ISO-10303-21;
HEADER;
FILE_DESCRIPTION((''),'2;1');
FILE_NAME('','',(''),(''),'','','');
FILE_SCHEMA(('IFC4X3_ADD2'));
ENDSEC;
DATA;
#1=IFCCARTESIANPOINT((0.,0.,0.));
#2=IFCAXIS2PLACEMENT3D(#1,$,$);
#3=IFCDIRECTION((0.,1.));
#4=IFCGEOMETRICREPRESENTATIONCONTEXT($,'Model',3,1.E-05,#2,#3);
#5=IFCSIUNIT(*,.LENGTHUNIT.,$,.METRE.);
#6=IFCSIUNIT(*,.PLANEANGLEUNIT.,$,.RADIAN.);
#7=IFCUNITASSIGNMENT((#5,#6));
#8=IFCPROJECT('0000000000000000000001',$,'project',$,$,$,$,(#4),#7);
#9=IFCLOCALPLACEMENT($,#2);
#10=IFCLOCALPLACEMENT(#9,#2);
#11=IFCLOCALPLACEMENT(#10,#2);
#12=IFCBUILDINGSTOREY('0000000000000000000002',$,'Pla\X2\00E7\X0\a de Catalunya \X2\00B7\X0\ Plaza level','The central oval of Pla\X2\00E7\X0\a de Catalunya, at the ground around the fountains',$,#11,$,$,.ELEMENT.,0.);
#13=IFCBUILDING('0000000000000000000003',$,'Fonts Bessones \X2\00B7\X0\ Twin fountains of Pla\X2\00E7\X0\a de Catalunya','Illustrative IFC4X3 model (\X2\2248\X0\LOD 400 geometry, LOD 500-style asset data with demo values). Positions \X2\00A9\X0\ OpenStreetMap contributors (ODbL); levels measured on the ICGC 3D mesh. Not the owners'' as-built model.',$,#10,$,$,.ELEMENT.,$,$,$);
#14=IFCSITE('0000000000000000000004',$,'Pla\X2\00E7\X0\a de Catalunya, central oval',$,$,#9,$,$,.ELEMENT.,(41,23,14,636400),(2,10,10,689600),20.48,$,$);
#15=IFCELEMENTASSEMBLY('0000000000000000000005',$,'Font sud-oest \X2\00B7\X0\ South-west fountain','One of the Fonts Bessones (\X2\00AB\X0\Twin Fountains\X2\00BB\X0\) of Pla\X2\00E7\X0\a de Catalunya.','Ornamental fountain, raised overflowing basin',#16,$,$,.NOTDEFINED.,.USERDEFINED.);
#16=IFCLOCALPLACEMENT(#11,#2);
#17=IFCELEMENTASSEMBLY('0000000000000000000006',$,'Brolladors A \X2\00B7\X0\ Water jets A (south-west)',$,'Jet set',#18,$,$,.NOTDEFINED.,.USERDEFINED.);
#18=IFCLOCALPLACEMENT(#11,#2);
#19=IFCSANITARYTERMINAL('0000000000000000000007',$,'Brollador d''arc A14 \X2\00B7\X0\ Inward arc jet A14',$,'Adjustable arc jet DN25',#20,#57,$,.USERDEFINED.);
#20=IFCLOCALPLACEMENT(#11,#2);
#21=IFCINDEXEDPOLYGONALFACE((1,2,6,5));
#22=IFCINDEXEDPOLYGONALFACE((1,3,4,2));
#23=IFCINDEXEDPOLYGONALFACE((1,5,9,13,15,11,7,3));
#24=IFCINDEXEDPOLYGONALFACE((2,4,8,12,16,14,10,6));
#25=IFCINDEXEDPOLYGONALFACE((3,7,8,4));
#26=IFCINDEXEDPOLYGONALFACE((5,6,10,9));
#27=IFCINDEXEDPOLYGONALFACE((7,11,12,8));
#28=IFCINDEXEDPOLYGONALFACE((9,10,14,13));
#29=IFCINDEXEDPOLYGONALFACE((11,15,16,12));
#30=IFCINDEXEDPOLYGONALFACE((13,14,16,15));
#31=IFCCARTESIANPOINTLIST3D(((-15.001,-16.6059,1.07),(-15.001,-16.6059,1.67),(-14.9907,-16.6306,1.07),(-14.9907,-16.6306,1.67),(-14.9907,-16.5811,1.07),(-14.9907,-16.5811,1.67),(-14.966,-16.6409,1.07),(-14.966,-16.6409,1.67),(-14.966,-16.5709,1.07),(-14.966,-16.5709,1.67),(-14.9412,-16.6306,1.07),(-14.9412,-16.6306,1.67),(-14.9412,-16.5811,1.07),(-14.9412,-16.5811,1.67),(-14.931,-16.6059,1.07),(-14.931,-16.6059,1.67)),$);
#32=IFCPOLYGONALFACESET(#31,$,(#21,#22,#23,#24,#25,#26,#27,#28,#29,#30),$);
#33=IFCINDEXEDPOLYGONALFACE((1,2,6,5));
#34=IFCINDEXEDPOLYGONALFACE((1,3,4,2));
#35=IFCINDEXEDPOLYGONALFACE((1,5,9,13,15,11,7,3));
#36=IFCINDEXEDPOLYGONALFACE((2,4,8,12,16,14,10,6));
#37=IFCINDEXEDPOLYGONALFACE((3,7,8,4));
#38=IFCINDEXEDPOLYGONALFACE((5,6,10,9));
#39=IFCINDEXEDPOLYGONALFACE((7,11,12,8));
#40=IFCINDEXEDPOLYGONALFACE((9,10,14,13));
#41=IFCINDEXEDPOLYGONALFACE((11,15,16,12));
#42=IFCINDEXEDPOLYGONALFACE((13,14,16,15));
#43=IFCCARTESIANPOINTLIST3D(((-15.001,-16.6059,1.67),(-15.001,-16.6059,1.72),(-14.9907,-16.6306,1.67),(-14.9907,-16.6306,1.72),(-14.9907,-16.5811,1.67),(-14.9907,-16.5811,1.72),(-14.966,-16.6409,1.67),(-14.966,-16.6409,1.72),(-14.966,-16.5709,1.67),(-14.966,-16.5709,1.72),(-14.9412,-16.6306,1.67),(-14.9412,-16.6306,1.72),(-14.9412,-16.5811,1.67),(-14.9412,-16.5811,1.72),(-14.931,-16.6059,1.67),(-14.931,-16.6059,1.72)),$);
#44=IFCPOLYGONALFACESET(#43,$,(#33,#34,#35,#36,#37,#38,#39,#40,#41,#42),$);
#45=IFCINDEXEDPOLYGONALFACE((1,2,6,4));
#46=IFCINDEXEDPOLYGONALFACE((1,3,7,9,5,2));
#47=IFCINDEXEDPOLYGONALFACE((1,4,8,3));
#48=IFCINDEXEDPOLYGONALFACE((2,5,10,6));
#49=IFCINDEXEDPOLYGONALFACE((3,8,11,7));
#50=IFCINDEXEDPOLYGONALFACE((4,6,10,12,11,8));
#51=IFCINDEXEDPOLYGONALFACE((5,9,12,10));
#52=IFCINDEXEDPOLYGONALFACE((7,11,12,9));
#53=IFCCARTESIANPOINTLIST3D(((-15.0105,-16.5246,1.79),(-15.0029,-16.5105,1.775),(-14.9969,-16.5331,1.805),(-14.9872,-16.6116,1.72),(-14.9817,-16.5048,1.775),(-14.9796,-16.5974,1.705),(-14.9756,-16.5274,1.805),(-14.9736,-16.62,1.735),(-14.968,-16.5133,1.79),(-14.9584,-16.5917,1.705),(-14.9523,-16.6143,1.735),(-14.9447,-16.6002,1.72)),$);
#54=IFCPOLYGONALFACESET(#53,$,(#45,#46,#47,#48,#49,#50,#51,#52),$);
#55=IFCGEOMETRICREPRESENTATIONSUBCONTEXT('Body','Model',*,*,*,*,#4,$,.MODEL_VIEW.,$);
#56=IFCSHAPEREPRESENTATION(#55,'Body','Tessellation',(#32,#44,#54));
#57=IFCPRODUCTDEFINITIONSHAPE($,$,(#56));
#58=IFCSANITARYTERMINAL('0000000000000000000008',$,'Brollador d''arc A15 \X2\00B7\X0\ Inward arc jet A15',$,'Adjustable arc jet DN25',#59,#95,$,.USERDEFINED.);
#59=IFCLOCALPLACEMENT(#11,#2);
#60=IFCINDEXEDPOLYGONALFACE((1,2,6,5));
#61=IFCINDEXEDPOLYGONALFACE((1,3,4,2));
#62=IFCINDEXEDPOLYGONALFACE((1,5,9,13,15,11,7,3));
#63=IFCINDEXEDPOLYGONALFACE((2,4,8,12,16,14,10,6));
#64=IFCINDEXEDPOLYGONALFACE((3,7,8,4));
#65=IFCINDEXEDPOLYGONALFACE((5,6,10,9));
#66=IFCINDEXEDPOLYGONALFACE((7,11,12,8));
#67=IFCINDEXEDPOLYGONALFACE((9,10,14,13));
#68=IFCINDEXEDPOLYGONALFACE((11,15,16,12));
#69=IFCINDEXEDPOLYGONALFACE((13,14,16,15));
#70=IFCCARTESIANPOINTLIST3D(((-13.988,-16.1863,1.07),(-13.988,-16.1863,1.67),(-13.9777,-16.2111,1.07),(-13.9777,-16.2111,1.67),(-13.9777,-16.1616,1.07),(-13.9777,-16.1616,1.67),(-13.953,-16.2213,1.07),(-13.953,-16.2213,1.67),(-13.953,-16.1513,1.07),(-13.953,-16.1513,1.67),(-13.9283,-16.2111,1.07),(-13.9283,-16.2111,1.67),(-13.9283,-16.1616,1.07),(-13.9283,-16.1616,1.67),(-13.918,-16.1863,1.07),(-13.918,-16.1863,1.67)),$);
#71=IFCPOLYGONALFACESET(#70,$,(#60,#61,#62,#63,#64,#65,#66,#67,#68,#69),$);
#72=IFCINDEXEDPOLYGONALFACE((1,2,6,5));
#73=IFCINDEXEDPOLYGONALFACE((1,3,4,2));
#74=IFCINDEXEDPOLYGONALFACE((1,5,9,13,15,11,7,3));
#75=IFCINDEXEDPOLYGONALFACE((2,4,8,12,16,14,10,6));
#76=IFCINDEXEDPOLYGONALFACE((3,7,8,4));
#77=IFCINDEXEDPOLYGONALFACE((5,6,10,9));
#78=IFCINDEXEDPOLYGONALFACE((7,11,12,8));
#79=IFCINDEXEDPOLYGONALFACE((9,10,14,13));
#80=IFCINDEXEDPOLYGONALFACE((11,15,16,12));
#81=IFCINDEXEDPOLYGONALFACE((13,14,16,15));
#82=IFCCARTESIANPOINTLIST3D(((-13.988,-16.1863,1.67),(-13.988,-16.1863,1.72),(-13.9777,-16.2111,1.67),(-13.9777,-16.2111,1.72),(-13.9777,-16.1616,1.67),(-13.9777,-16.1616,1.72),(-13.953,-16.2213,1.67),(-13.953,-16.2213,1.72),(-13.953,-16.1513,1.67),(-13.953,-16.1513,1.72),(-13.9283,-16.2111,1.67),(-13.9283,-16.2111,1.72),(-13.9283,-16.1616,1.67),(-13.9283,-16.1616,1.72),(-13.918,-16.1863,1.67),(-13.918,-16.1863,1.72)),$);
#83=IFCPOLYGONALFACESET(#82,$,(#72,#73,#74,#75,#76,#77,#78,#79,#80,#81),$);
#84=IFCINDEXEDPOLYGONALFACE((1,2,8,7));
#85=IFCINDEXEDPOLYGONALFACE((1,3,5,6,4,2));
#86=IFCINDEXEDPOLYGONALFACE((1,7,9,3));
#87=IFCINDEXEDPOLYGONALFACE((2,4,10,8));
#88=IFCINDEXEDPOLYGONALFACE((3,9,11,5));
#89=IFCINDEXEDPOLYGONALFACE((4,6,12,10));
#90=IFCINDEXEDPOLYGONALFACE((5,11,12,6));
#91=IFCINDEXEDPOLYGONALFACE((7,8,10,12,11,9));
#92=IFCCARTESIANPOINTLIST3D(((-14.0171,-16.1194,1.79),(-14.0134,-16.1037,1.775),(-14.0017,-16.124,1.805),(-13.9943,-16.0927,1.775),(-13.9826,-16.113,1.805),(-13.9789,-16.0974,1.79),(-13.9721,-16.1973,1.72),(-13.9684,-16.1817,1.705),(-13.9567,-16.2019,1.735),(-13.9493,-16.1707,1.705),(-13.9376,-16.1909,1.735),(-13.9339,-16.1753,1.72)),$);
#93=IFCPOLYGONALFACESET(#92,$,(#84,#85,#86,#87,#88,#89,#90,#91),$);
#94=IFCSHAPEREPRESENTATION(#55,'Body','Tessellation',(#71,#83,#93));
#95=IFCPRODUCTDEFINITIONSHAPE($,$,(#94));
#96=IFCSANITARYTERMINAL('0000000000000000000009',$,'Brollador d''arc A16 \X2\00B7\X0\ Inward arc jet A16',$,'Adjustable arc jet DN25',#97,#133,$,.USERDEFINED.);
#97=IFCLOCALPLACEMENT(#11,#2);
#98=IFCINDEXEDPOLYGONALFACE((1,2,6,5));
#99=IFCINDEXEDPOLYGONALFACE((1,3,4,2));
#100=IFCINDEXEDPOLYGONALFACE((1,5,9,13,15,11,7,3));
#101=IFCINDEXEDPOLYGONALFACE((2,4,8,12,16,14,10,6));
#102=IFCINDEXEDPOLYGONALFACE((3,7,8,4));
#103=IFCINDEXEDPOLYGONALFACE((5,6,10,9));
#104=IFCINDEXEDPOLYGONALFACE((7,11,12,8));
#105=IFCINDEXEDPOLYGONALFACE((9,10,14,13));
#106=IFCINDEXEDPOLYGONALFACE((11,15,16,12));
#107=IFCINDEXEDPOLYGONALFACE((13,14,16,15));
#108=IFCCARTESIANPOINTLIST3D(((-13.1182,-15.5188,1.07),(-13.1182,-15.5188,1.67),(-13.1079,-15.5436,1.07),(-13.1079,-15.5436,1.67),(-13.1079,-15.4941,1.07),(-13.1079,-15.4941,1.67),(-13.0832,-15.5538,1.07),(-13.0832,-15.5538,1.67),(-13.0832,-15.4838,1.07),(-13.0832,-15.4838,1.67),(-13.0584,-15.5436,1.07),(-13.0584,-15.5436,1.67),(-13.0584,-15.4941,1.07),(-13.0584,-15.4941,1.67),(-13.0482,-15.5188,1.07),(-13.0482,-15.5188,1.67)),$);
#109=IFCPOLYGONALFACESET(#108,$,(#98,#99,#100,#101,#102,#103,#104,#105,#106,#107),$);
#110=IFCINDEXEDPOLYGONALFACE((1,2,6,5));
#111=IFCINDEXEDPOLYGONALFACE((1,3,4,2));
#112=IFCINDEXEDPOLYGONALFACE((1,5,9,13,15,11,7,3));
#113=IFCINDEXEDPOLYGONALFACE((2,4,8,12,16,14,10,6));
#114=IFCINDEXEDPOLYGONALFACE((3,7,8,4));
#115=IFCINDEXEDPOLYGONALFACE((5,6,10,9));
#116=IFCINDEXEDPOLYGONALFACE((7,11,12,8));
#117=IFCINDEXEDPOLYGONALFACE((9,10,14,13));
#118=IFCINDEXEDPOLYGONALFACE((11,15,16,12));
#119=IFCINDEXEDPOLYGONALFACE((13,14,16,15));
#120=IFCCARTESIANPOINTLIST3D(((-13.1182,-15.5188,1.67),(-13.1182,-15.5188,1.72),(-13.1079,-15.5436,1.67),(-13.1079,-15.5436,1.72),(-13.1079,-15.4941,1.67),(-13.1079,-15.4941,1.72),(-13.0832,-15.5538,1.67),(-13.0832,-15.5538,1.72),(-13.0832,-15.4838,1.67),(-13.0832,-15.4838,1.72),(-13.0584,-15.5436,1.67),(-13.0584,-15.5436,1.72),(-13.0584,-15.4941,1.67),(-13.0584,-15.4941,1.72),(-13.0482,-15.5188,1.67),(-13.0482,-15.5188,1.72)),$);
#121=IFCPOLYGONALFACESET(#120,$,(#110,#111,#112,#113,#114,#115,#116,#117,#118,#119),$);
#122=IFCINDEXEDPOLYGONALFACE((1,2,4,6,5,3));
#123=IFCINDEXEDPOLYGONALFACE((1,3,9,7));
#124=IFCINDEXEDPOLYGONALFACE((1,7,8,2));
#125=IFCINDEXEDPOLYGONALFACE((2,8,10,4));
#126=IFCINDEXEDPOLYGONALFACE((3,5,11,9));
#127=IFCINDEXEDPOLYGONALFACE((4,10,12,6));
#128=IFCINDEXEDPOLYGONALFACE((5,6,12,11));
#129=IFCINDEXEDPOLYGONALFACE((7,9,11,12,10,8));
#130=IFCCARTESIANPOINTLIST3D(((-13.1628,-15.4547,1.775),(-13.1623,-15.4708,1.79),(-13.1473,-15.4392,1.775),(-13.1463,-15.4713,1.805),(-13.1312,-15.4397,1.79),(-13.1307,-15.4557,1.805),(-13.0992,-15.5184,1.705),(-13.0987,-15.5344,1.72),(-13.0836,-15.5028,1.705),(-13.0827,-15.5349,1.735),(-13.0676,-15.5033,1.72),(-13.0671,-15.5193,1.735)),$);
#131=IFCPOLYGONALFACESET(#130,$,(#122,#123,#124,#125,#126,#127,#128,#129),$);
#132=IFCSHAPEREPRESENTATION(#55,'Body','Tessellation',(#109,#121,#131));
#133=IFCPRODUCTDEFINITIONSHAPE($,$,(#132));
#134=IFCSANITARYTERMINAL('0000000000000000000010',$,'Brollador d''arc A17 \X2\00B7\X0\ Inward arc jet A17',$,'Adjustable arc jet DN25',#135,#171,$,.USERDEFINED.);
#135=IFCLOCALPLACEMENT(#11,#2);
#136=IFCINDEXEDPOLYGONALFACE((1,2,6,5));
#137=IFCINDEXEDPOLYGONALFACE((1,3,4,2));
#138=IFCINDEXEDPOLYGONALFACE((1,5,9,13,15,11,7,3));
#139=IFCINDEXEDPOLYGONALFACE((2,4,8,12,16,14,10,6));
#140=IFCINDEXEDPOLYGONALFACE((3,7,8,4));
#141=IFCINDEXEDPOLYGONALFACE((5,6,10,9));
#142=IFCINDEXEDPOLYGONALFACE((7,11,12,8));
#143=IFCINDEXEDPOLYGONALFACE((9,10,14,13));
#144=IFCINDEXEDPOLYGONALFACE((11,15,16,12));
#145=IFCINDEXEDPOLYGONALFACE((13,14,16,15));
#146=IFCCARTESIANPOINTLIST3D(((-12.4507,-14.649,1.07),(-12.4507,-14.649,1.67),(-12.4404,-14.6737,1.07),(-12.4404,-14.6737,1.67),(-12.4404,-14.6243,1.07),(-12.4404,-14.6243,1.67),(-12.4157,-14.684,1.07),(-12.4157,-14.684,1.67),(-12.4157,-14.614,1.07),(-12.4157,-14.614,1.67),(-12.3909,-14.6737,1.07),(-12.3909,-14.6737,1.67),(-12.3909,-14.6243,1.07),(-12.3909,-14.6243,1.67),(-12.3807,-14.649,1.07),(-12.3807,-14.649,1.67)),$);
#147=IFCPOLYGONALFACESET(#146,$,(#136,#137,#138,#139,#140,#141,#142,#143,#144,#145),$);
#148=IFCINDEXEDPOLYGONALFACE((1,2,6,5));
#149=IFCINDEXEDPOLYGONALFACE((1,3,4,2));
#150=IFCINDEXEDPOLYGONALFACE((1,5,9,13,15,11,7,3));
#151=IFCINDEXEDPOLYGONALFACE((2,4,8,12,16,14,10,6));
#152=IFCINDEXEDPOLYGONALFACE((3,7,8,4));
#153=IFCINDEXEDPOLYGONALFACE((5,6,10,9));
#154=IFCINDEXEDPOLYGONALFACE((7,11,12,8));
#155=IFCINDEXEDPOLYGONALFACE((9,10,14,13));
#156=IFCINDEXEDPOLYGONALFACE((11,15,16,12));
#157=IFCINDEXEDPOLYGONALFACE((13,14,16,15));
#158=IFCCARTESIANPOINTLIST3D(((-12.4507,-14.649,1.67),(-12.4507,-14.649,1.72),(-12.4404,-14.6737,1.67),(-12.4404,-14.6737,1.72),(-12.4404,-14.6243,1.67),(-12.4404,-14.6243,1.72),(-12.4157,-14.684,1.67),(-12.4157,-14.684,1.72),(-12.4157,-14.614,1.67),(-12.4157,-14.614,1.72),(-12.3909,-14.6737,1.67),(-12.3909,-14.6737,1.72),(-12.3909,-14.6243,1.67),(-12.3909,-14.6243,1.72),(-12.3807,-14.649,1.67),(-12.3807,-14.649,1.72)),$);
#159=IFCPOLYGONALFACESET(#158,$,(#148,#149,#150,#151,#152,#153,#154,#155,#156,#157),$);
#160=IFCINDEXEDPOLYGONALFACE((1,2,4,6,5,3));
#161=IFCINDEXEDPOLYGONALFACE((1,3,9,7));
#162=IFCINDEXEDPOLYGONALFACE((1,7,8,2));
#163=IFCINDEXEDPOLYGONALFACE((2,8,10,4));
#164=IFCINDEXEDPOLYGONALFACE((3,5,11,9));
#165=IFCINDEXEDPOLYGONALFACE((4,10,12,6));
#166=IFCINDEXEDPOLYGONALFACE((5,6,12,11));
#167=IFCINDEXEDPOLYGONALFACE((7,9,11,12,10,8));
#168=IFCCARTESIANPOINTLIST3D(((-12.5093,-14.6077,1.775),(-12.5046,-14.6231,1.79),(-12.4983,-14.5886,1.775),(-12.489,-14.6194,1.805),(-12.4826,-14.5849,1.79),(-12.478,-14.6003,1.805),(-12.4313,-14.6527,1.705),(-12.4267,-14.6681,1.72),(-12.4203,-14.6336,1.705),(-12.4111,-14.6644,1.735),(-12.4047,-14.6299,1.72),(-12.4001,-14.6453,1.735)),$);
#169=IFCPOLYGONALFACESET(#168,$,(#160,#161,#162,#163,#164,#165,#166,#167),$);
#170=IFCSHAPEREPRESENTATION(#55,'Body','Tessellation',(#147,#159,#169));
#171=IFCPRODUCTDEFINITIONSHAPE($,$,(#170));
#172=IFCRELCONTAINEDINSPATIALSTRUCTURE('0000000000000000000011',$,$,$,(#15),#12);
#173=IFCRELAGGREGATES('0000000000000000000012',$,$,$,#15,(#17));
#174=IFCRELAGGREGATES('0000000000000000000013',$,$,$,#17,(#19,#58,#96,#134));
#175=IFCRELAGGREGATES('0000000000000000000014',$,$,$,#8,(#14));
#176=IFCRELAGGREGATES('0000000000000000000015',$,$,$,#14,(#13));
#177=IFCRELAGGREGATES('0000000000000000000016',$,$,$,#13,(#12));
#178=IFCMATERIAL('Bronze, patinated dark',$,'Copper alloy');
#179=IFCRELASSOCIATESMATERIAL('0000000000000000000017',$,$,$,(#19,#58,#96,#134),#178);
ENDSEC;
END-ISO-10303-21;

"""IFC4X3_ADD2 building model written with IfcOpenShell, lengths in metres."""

from ifc_helpers import new_model, si_unit, direction, frame, origin, place, context, subcontext, project, spatial, polyline, outline, extrude, material, element, aggregate, save


model = new_model("IFC4X3_ADD2")

# Units and contexts
model_context = context("Model", 3, precision=1e-05, world=origin(), true_north=direction((0.0, 1.0)))
body_context = subcontext(model_context, "Body", "Model", "MODEL_VIEW")
ifc_project = project(units=[si_unit("LENGTHUNIT", "METRE"), si_unit("PLANEANGLEUNIT", "RADIAN")], contexts=[model_context])

# Site, building, storey
site_placement = place(None, origin())
site = spatial("IfcSite", under=ifc_project, at=site_placement, Name="Plaça de Catalunya, central oval", CompositionType="ELEMENT", RefLatitude=(41, 23, 14, 636400), RefLongitude=(2, 10, 10, 689600), RefElevation=20.48)
building_placement = place(site_placement, origin())
building = spatial("IfcBuilding", under=site, at=building_placement, Name="Fonts Bessones · Twin fountains of Plaça de Catalunya", Description="Illustrative IFC4X3 model (≈LOD 400 geometry, LOD 500-style asset data with demo values). Positions © OpenStreetMap contributors (ODbL); levels measured on the ICGC 3D mesh. Not the owners' as-built model.", CompositionType="ELEMENT")
storey_placement = place(building_placement, origin())
storey = spatial("IfcBuildingStorey", under=building, at=storey_placement, Name="Plaça de Catalunya · Plaza level", Description="The central oval of Plaça de Catalunya, at the ground around the fountains", CompositionType="ELEMENT", Elevation=0.0)

# Element assemblies, sanitary terminals
assembly_1_placement = place(building_placement, origin())
assembly_1 = element("IfcElementAssembly", 1, at=assembly_1_placement, inside=storey, Name="Font sud-oest · South-west fountain", Description="One of the Fonts Bessones («Twin Fountains») of Plaça de Catalunya.", ObjectType="Ornamental fountain, raised overflowing basin", AssemblyPlace="NOTDEFINED", PredefinedType="USERDEFINED")
assembly_2_placement = place(building_placement, origin())
assembly_2 = element("IfcElementAssembly", 2, at=assembly_2_placement, Name="Brolladors A · Water jets A (south-west)", ObjectType="Jet set", AssemblyPlace="NOTDEFINED", PredefinedType="USERDEFINED")
aggregate(assembly_1, [assembly_2])
ifc_material = material(Name="Bronze, patinated dark", Category="Copper alloy")
sanitary_terminal_1_placement = place(building_placement, origin())
sanitary_terminal_1 = element("IfcSanitaryTerminal", 3, at=sanitary_terminal_1_placement, material=ifc_material, Name="Brollador d'arc A14 · Inward arc jet A14", ObjectType="Adjustable arc jet DN25", PredefinedType="USERDEFINED", context=body_context, shape_type="SweptSolid", body=[
    extrude(outline(polyline([(-14.931, -16.6059), (-14.9412, -16.5811), (-14.966, -16.5709), (-14.9907, -16.5811), (-15.001, -16.6059), (-14.9907, -16.6306), (-14.966, -16.6409), (-14.9412, -16.6306), (-14.931, -16.6059)])), frame((0.0, 0.0, 1.07)), (0.0, 0.0, 1.0), 0.6),
    extrude(outline(polyline([(-14.931, -16.6059), (-14.9412, -16.5811), (-14.966, -16.5709), (-14.9907, -16.5811), (-15.001, -16.6059), (-14.9907, -16.6306), (-14.966, -16.6409), (-14.9412, -16.6306), (-14.931, -16.6059)])), frame((0.0, 0.0, 1.67)), (0.0, 0.0, 1.0), 0.05),
    extrude(outline(polyline([(0.022, 0.0), (0.011, 0.0191), (-0.011, 0.0191), (-0.022, 0.0), (-0.011, -0.0191), (0.011, -0.0191), (0.022, 0.0)])), frame((-14.966, -16.6059, 1.72), z_axis=(-0.204299, 0.762456, 0.613941), x_axis=(0.965926, 0.258819, 0.0)), (0.0, 0.0, 1.0), 0.114),
])
sanitary_terminal_2_placement = place(building_placement, origin())
sanitary_terminal_2 = element("IfcSanitaryTerminal", 4, at=sanitary_terminal_2_placement, material=ifc_material, Name="Brollador d'arc A15 · Inward arc jet A15", ObjectType="Adjustable arc jet DN25", PredefinedType="USERDEFINED", context=body_context, shape_type="SweptSolid", body=[
    extrude(outline(polyline([(-13.918, -16.1863), (-13.9283, -16.1616), (-13.953, -16.1513), (-13.9777, -16.1616), (-13.988, -16.1863), (-13.9777, -16.2111), (-13.953, -16.2213), (-13.9283, -16.2111), (-13.918, -16.1863)])), frame((0.0, 0.0, 1.07)), (0.0, 0.0, 1.0), 0.6),
    extrude(outline(polyline([(-13.918, -16.1863), (-13.9283, -16.1616), (-13.953, -16.1513), (-13.9777, -16.1616), (-13.988, -16.1863), (-13.9777, -16.2111), (-13.953, -16.2213), (-13.9283, -16.2111), (-13.918, -16.1863)])), frame((0.0, 0.0, 1.67)), (0.0, 0.0, 1.0), 0.05),
    extrude(outline(polyline([(0.022, 0.0), (0.011, 0.0191), (-0.011, 0.0191), (-0.022, 0.0), (-0.011, -0.0191), (0.011, -0.0191), (0.022, 0.0)])), frame((-13.953, -16.1863, 1.72), z_axis=(-0.394676, 0.683599, 0.613941), x_axis=(0.866025, 0.5, 0.0)), (0.0, 0.0, 1.0), 0.114),
])
sanitary_terminal_3_placement = place(building_placement, origin())
sanitary_terminal_3 = element("IfcSanitaryTerminal", 5, at=sanitary_terminal_3_placement, material=ifc_material, Name="Brollador d'arc A16 · Inward arc jet A16", ObjectType="Adjustable arc jet DN25", PredefinedType="USERDEFINED", context=body_context, shape_type="SweptSolid", body=[
    extrude(outline(polyline([(-13.0482, -15.5188), (-13.0584, -15.4941), (-13.0832, -15.4838), (-13.1079, -15.4941), (-13.1182, -15.5188), (-13.1079, -15.5436), (-13.0832, -15.5538), (-13.0584, -15.5436), (-13.0482, -15.5188)])), frame((0.0, 0.0, 1.07)), (0.0, 0.0, 1.0), 0.6),
    extrude(outline(polyline([(-13.0482, -15.5188), (-13.0584, -15.4941), (-13.0832, -15.4838), (-13.1079, -15.4941), (-13.1182, -15.5188), (-13.1079, -15.5436), (-13.0832, -15.5538), (-13.0584, -15.5436), (-13.0482, -15.5188)])), frame((0.0, 0.0, 1.67)), (0.0, 0.0, 1.0), 0.05),
    extrude(outline(polyline([(0.022, 0.0), (0.011, 0.0191), (-0.011, 0.0191), (-0.022, 0.0), (-0.011, -0.0191), (0.011, -0.0191), (0.022, 0.0)])), frame((-13.0832, -15.5188, 1.72), z_axis=(-0.558156, 0.558156, 0.613941), x_axis=(0.707107, 0.707107, 0.0)), (0.0, 0.0, 1.0), 0.114),
])
sanitary_terminal_4_placement = place(building_placement, origin())
sanitary_terminal_4 = element("IfcSanitaryTerminal", 6, at=sanitary_terminal_4_placement, material=ifc_material, Name="Brollador d'arc A17 · Inward arc jet A17", ObjectType="Adjustable arc jet DN25", PredefinedType="USERDEFINED", context=body_context, shape_type="SweptSolid", body=[
    extrude(outline(polyline([(-12.3807, -14.649), (-12.3909, -14.6243), (-12.4157, -14.614), (-12.4404, -14.6243), (-12.4507, -14.649), (-12.4404, -14.6737), (-12.4157, -14.684), (-12.3909, -14.6737), (-12.3807, -14.649)])), frame((0.0, 0.0, 1.07)), (0.0, 0.0, 1.0), 0.6),
    extrude(outline(polyline([(-12.3807, -14.649), (-12.3909, -14.6243), (-12.4157, -14.614), (-12.4404, -14.6243), (-12.4507, -14.649), (-12.4404, -14.6737), (-12.4157, -14.684), (-12.3909, -14.6737), (-12.3807, -14.649)])), frame((0.0, 0.0, 1.67)), (0.0, 0.0, 1.0), 0.05),
    extrude(outline(polyline([(0.022, 0.0), (0.011, 0.0191), (-0.011, 0.0191), (-0.022, 0.0), (-0.011, -0.0191), (0.011, -0.0191), (0.022, 0.0)])), frame((-12.4157, -14.649, 1.72), z_axis=(-0.683599, 0.394676, 0.613941), x_axis=(0.5, 0.866025, 0.0)), (0.0, 0.0, 1.0), 0.114),
])
aggregate(assembly_2, [sanitary_terminal_1, sanitary_terminal_2, sanitary_terminal_3, sanitary_terminal_4])

save(model, "model.ifc")
